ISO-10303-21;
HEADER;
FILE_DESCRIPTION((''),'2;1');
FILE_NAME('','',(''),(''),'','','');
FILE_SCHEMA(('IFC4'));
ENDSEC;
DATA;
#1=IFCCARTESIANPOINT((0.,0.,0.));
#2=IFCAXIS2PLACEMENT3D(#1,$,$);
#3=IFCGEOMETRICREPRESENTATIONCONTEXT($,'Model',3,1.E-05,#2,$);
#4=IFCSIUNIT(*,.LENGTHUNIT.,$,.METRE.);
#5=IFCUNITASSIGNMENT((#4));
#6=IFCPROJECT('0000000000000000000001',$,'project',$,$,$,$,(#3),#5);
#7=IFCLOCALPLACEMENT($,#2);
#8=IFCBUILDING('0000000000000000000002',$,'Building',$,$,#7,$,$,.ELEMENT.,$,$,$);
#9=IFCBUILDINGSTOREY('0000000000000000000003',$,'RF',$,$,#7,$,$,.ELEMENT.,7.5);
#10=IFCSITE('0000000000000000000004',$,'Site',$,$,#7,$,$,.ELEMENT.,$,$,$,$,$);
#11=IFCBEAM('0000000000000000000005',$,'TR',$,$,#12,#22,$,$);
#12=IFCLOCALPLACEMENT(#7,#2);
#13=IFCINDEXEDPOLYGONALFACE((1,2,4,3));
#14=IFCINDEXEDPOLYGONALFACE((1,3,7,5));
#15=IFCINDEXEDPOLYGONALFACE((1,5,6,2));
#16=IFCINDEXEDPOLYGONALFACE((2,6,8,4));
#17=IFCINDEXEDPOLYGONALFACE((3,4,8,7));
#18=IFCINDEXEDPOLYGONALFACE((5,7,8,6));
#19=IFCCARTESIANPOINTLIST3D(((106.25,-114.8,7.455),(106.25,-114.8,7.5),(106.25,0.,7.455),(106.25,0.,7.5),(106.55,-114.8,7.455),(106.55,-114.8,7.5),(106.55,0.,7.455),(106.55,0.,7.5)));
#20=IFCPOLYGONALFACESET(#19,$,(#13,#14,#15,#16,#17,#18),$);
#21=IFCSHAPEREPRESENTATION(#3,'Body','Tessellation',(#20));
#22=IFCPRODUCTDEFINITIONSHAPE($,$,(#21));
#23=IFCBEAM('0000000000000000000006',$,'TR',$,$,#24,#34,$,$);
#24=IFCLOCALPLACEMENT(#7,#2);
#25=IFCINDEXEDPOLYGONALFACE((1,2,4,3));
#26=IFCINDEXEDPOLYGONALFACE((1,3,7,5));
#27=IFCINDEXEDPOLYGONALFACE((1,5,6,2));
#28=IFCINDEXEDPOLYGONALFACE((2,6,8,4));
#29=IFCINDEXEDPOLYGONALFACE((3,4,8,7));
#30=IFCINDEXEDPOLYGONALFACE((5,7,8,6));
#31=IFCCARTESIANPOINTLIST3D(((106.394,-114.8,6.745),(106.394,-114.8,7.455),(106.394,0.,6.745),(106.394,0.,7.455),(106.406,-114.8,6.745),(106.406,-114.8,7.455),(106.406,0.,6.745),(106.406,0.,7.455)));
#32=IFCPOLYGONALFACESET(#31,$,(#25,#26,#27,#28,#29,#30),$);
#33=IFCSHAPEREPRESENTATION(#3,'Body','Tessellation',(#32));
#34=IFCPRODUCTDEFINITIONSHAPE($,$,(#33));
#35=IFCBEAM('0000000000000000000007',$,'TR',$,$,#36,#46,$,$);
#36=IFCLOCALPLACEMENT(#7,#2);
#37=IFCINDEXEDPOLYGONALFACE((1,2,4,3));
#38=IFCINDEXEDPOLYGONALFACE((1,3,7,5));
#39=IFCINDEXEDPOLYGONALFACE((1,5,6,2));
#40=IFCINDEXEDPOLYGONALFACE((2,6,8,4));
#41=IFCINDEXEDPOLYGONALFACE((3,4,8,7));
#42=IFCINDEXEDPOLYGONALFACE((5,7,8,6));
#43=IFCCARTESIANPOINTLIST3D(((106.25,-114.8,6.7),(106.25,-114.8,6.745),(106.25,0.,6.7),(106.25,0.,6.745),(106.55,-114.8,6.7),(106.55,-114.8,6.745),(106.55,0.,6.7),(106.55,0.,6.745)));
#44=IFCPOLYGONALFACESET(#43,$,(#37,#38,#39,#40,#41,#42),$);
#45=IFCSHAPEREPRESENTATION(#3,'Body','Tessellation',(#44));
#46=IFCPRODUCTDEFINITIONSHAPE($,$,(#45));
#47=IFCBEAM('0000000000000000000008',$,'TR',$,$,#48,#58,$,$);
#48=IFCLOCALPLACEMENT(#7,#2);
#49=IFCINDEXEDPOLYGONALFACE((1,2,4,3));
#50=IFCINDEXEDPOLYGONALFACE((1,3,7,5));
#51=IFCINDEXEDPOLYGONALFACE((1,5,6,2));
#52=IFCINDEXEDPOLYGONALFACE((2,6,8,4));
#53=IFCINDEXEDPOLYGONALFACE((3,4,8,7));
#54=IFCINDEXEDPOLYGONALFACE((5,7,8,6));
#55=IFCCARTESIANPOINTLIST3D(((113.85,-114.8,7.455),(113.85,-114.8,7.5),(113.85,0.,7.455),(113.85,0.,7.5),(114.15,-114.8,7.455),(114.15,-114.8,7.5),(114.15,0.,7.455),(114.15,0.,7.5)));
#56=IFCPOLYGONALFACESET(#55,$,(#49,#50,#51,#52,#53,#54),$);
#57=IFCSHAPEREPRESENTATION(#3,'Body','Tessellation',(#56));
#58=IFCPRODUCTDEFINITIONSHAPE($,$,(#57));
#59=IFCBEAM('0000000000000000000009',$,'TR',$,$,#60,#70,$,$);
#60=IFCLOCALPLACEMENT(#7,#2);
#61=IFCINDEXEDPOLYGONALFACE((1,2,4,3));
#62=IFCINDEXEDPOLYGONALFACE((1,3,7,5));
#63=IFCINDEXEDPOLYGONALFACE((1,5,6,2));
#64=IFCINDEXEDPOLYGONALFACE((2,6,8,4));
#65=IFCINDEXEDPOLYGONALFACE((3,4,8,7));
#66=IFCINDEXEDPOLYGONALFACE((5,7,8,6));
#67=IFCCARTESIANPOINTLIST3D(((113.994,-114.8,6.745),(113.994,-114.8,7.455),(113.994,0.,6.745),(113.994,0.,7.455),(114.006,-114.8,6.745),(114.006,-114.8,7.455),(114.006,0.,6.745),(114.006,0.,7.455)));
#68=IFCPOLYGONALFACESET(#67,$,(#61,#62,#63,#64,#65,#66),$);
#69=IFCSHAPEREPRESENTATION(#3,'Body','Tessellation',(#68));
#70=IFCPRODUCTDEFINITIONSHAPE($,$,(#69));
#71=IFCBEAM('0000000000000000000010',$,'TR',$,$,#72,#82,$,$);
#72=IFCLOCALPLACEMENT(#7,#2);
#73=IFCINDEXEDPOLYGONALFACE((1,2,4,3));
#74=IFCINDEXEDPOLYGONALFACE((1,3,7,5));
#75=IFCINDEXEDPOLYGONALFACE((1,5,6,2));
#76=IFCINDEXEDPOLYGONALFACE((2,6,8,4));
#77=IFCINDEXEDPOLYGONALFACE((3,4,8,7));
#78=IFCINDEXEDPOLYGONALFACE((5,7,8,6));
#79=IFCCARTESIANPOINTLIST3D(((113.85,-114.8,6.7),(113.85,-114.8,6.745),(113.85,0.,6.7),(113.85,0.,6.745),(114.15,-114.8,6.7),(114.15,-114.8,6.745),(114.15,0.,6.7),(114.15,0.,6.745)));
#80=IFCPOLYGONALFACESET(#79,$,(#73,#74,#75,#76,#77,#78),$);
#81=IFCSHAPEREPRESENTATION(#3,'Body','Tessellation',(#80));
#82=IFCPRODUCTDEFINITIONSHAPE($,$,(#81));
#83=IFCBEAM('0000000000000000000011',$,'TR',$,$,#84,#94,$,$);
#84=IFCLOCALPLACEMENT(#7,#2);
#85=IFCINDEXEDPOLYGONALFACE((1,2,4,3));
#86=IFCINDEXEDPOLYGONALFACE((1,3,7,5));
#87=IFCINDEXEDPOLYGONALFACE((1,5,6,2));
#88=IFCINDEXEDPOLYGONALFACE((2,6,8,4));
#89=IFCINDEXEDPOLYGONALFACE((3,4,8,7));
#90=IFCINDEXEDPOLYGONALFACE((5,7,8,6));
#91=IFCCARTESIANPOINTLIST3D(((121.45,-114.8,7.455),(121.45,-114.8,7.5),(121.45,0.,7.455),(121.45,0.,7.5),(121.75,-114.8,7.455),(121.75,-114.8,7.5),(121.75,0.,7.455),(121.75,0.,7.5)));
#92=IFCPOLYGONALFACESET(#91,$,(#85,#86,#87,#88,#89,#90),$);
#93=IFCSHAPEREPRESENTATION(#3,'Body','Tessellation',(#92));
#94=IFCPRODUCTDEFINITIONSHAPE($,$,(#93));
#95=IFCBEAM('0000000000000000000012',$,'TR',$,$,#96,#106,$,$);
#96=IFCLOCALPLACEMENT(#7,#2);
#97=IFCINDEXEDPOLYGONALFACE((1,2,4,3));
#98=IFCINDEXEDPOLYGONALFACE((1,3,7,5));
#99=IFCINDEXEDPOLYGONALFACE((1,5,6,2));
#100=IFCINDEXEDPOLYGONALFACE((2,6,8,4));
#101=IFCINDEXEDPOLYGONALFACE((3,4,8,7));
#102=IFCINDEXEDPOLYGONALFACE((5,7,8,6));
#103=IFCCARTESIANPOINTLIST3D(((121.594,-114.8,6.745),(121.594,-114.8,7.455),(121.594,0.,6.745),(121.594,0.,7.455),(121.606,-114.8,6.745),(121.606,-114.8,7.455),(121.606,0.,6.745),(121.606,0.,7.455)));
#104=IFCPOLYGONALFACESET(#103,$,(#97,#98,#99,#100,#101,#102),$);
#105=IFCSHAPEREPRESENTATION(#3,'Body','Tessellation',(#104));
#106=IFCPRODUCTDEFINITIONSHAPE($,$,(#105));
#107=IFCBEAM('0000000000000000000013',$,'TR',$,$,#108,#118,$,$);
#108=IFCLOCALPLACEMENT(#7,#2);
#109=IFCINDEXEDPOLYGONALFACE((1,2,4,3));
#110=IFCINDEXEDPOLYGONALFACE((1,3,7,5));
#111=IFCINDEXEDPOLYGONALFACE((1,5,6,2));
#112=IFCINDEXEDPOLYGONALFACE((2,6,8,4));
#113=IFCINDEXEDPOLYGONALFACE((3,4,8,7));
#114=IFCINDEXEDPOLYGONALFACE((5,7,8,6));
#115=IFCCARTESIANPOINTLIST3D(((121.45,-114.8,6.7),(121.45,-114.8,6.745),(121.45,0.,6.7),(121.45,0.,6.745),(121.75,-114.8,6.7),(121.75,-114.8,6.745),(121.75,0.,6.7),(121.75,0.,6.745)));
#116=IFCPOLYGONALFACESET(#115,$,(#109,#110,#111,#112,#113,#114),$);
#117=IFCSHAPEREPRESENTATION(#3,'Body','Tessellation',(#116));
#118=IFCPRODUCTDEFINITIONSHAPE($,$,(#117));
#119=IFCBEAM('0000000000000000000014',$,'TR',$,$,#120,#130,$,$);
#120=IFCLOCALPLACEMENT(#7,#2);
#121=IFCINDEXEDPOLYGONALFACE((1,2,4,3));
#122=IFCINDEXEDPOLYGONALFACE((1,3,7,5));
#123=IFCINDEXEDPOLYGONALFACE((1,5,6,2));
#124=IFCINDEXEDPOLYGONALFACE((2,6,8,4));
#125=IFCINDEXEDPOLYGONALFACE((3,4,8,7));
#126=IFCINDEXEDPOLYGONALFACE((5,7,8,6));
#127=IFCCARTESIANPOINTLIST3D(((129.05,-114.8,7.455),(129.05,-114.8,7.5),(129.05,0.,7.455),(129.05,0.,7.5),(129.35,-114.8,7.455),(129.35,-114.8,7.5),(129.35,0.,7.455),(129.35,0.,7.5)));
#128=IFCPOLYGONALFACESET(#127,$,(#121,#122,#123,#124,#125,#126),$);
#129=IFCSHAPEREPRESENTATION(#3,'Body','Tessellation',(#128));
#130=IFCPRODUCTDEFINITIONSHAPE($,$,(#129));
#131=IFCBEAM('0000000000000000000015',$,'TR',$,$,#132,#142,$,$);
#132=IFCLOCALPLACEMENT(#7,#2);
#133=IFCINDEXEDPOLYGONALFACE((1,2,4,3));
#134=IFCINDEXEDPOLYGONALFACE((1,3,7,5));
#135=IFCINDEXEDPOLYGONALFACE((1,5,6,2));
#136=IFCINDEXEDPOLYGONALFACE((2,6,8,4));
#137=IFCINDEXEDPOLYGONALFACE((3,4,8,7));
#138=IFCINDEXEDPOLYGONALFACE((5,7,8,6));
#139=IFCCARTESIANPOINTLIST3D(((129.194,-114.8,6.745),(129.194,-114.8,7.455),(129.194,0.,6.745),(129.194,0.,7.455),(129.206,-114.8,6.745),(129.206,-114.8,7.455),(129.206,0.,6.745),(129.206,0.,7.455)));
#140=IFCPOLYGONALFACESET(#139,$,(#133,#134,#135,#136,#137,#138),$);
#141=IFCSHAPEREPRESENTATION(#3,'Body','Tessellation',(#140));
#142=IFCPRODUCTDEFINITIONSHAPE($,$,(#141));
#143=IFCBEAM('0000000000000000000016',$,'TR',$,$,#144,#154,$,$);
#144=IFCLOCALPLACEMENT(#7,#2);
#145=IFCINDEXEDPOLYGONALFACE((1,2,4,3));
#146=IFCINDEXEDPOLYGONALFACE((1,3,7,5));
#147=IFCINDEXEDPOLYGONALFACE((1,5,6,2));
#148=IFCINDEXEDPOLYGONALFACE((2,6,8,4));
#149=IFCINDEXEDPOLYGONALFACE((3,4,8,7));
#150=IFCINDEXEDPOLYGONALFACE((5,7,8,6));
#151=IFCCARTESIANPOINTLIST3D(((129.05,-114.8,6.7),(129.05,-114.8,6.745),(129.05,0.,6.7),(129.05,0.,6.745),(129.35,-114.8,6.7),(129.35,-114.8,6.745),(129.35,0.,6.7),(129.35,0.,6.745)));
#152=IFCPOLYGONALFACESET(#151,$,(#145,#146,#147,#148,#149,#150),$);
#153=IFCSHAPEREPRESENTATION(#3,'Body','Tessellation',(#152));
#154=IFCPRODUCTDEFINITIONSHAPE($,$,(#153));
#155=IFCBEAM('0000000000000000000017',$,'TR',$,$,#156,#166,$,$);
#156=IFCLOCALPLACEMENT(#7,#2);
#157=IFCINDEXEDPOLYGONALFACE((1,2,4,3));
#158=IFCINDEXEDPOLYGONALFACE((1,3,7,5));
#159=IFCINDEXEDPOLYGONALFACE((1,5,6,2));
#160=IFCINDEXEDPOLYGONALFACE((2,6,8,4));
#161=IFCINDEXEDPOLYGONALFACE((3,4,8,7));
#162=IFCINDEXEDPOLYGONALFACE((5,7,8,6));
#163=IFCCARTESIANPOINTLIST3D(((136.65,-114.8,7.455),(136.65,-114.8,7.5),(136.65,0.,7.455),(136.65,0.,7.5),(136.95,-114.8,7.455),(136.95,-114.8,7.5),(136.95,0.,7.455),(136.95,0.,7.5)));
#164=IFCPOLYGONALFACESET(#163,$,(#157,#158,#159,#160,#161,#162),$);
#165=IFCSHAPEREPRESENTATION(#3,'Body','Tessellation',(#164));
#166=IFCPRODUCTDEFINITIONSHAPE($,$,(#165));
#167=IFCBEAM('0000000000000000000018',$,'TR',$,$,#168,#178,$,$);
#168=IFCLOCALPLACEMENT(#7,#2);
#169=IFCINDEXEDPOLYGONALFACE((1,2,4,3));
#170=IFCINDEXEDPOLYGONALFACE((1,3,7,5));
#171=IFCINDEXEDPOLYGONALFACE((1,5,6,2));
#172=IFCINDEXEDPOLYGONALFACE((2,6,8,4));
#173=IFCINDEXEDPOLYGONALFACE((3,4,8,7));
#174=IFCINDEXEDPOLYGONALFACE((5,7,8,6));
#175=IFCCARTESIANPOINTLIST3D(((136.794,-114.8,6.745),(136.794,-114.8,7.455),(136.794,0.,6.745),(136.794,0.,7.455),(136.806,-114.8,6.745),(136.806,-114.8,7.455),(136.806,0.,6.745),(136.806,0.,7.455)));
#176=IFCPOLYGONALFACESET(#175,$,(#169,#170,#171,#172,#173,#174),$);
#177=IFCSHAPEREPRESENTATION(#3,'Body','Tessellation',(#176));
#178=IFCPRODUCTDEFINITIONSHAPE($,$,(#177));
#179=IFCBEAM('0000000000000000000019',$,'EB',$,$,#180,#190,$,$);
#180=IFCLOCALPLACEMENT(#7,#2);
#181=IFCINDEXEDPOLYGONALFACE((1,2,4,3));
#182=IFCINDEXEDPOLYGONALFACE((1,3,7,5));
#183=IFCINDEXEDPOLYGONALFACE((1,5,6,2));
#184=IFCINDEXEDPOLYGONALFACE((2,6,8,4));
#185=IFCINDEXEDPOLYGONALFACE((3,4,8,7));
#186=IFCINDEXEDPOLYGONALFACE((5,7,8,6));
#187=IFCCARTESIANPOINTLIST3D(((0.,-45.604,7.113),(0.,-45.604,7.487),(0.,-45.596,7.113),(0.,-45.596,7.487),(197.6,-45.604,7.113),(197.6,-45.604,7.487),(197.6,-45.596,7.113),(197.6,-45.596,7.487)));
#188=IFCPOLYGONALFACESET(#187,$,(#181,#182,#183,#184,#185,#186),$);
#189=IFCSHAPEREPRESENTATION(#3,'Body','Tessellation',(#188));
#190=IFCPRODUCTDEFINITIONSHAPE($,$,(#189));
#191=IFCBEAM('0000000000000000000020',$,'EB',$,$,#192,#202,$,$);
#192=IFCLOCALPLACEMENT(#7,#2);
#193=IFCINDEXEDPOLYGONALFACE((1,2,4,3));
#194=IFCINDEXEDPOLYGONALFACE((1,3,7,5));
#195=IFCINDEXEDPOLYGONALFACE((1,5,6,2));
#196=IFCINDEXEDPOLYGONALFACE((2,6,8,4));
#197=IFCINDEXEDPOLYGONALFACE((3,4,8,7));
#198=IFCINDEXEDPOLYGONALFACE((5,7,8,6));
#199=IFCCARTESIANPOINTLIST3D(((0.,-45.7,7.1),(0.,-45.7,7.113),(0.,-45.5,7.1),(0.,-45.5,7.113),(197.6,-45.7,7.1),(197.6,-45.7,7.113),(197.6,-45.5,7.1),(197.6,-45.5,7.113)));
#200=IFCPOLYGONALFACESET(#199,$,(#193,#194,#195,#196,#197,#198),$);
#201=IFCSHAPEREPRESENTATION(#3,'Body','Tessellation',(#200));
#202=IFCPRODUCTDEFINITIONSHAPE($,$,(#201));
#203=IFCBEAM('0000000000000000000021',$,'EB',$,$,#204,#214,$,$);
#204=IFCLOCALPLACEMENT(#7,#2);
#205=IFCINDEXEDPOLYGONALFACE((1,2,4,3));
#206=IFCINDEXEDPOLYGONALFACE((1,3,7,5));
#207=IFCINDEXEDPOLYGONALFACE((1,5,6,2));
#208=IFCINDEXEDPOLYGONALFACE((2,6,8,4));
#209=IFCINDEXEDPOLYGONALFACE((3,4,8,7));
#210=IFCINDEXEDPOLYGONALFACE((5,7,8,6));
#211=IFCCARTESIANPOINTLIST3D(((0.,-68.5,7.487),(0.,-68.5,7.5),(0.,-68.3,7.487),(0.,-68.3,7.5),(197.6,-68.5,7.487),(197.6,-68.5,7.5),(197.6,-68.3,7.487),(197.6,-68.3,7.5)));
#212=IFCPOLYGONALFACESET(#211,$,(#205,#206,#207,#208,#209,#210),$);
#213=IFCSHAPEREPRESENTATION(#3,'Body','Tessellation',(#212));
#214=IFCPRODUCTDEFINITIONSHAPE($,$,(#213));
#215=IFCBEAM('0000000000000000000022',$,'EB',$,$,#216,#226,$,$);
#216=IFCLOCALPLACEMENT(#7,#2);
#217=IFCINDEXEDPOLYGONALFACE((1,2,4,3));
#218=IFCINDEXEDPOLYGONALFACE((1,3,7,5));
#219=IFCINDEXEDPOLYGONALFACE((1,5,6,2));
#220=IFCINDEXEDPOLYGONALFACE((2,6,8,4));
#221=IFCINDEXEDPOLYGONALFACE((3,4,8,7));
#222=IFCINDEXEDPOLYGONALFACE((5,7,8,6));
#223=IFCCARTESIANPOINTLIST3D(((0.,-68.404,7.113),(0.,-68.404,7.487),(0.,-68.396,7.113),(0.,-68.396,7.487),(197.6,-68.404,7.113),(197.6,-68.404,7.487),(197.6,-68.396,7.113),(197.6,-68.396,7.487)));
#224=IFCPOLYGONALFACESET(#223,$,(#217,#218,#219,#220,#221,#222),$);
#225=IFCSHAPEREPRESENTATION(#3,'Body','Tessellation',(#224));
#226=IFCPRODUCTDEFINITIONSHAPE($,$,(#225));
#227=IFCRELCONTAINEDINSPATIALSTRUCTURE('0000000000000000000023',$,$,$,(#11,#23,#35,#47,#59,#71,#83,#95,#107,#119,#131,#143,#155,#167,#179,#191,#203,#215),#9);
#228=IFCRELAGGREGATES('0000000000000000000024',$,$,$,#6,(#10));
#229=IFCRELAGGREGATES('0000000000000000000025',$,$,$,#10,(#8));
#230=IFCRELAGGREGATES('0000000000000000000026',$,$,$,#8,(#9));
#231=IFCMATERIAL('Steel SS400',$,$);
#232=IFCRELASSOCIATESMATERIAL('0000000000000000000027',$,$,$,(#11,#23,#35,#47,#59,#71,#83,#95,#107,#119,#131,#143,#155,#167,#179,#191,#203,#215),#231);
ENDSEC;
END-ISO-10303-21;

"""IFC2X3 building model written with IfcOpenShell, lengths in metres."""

from ifc_helpers import new_model, si_unit, frame, origin, origin_2d, place, context, project, spatial, rectangle, extrude, material, element, save


model = new_model("IFC2X3")

# Units and contexts
model_context = context("Model", 3, precision=1e-05, world=origin())
ifc_project = project(units=[si_unit("LENGTHUNIT", "METRE")], contexts=[model_context])

# Site, building, storey
placement = place(None, origin())
site = spatial("IfcSite", under=ifc_project, at=placement, Name="Site", CompositionType="ELEMENT")
building = spatial("IfcBuilding", under=site, at=placement, Name="Building", CompositionType="ELEMENT")
storey = spatial("IfcBuildingStorey", under=building, at=placement, Name="RF", CompositionType="ELEMENT", Elevation=7.5)

# Beams
ifc_material = material(Name="Steel SS400")
beam_1_placement = place(None, frame((106.4, -57.4, 7.455)))
element("IfcBeam", 1, at=beam_1_placement, inside=storey, material=ifc_material, Name="TR", context=model_context, shape_type="SweptSolid", body=[
    extrude(rectangle(XDim=0.3, YDim=114.8, at=origin_2d()), origin(), (0.0, 0.0, 1.0), 0.045),
])
beam_2_placement = place(None, frame((106.4, -57.4, 6.745)))
element("IfcBeam", 2, at=beam_2_placement, inside=storey, material=ifc_material, Name="TR", context=model_context, shape_type="SweptSolid", body=[
    extrude(rectangle(XDim=0.012, YDim=114.8, at=origin_2d()), origin(), (0.0, 0.0, 1.0), 0.71),
])
for number, where, name in (
    (3, (106.4, -57.4, 6.7), "TR"),
    (4, (114.0, -57.4, 7.455), "TR"),
):
    element("IfcBeam", number, at=place(None, frame(where)), inside=storey, material=ifc_material, Name=name, context=model_context, shape_type="SweptSolid", body=[
        extrude(rectangle(XDim=0.3, YDim=114.8, at=origin_2d()), origin(), (0.0, 0.0, 1.0), 0.045),
    ])
beam_3_placement = place(None, frame((114.0, -57.4, 6.745)))
element("IfcBeam", 5, at=beam_3_placement, inside=storey, material=ifc_material, Name="TR", context=model_context, shape_type="SweptSolid", body=[
    extrude(rectangle(XDim=0.012, YDim=114.8, at=origin_2d()), origin(), (0.0, 0.0, 1.0), 0.71),
])
for number, where, name in (
    (6, (114.0, -57.4, 6.7), "TR"),
    (7, (121.6, -57.4, 7.455), "TR"),
):
    element("IfcBeam", number, at=place(None, frame(where)), inside=storey, material=ifc_material, Name=name, context=model_context, shape_type="SweptSolid", body=[
        extrude(rectangle(XDim=0.3, YDim=114.8, at=origin_2d()), origin(), (0.0, 0.0, 1.0), 0.045),
    ])
beam_4_placement = place(None, frame((121.6, -57.4, 6.745)))
element("IfcBeam", 8, at=beam_4_placement, inside=storey, material=ifc_material, Name="TR", context=model_context, shape_type="SweptSolid", body=[
    extrude(rectangle(XDim=0.012, YDim=114.8, at=origin_2d()), origin(), (0.0, 0.0, 1.0), 0.71),
])
for number, where, name in (
    (9, (121.6, -57.4, 6.7), "TR"),
    (10, (129.2, -57.4, 7.455), "TR"),
):
    element("IfcBeam", number, at=place(None, frame(where)), inside=storey, material=ifc_material, Name=name, context=model_context, shape_type="SweptSolid", body=[
        extrude(rectangle(XDim=0.3, YDim=114.8, at=origin_2d()), origin(), (0.0, 0.0, 1.0), 0.045),
    ])
beam_5_placement = place(None, frame((129.2, -57.4, 6.745)))
element("IfcBeam", 11, at=beam_5_placement, inside=storey, material=ifc_material, Name="TR", context=model_context, shape_type="SweptSolid", body=[
    extrude(rectangle(XDim=0.012, YDim=114.8, at=origin_2d()), origin(), (0.0, 0.0, 1.0), 0.71),
])
for number, where, name in (
    (12, (129.2, -57.4, 6.7), "TR"),
    (13, (136.8, -57.4, 7.455), "TR"),
):
    element("IfcBeam", number, at=place(None, frame(where)), inside=storey, material=ifc_material, Name=name, context=model_context, shape_type="SweptSolid", body=[
        extrude(rectangle(XDim=0.3, YDim=114.8, at=origin_2d()), origin(), (0.0, 0.0, 1.0), 0.045),
    ])
beam_6_placement = place(None, frame((136.8, -57.4, 6.745)))
element("IfcBeam", 14, at=beam_6_placement, inside=storey, material=ifc_material, Name="TR", context=model_context, shape_type="SweptSolid", body=[
    extrude(rectangle(XDim=0.012, YDim=114.8, at=origin_2d()), origin(), (0.0, 0.0, 1.0), 0.71),
])
beam_7_placement = place(None, frame((98.8, -45.6, 7.113)))
element("IfcBeam", 15, at=beam_7_placement, inside=storey, material=ifc_material, Name="EB", context=model_context, shape_type="SweptSolid", body=[
    extrude(rectangle(XDim=197.6, YDim=0.008, at=origin_2d()), origin(), (0.0, 0.0, 1.0), 0.374),
])
for number, where, name in (
    (16, (98.8, -45.6, 7.1), "EB"),
    (17, (98.8, -68.4, 7.487), "EB"),
):
    element("IfcBeam", number, at=place(None, frame(where)), inside=storey, material=ifc_material, Name=name, context=model_context, shape_type="SweptSolid", body=[
        extrude(rectangle(XDim=197.6, YDim=0.2, at=origin_2d()), origin(), (0.0, 0.0, 1.0), 0.013),
    ])
beam_8_placement = place(None, frame((98.8, -68.4, 7.113)))
element("IfcBeam", 18, at=beam_8_placement, inside=storey, material=ifc_material, Name="EB", context=model_context, shape_type="SweptSolid", body=[
    extrude(rectangle(XDim=197.6, YDim=0.008, at=origin_2d()), origin(), (0.0, 0.0, 1.0), 0.374),
])

save(model, "model.ifc")
